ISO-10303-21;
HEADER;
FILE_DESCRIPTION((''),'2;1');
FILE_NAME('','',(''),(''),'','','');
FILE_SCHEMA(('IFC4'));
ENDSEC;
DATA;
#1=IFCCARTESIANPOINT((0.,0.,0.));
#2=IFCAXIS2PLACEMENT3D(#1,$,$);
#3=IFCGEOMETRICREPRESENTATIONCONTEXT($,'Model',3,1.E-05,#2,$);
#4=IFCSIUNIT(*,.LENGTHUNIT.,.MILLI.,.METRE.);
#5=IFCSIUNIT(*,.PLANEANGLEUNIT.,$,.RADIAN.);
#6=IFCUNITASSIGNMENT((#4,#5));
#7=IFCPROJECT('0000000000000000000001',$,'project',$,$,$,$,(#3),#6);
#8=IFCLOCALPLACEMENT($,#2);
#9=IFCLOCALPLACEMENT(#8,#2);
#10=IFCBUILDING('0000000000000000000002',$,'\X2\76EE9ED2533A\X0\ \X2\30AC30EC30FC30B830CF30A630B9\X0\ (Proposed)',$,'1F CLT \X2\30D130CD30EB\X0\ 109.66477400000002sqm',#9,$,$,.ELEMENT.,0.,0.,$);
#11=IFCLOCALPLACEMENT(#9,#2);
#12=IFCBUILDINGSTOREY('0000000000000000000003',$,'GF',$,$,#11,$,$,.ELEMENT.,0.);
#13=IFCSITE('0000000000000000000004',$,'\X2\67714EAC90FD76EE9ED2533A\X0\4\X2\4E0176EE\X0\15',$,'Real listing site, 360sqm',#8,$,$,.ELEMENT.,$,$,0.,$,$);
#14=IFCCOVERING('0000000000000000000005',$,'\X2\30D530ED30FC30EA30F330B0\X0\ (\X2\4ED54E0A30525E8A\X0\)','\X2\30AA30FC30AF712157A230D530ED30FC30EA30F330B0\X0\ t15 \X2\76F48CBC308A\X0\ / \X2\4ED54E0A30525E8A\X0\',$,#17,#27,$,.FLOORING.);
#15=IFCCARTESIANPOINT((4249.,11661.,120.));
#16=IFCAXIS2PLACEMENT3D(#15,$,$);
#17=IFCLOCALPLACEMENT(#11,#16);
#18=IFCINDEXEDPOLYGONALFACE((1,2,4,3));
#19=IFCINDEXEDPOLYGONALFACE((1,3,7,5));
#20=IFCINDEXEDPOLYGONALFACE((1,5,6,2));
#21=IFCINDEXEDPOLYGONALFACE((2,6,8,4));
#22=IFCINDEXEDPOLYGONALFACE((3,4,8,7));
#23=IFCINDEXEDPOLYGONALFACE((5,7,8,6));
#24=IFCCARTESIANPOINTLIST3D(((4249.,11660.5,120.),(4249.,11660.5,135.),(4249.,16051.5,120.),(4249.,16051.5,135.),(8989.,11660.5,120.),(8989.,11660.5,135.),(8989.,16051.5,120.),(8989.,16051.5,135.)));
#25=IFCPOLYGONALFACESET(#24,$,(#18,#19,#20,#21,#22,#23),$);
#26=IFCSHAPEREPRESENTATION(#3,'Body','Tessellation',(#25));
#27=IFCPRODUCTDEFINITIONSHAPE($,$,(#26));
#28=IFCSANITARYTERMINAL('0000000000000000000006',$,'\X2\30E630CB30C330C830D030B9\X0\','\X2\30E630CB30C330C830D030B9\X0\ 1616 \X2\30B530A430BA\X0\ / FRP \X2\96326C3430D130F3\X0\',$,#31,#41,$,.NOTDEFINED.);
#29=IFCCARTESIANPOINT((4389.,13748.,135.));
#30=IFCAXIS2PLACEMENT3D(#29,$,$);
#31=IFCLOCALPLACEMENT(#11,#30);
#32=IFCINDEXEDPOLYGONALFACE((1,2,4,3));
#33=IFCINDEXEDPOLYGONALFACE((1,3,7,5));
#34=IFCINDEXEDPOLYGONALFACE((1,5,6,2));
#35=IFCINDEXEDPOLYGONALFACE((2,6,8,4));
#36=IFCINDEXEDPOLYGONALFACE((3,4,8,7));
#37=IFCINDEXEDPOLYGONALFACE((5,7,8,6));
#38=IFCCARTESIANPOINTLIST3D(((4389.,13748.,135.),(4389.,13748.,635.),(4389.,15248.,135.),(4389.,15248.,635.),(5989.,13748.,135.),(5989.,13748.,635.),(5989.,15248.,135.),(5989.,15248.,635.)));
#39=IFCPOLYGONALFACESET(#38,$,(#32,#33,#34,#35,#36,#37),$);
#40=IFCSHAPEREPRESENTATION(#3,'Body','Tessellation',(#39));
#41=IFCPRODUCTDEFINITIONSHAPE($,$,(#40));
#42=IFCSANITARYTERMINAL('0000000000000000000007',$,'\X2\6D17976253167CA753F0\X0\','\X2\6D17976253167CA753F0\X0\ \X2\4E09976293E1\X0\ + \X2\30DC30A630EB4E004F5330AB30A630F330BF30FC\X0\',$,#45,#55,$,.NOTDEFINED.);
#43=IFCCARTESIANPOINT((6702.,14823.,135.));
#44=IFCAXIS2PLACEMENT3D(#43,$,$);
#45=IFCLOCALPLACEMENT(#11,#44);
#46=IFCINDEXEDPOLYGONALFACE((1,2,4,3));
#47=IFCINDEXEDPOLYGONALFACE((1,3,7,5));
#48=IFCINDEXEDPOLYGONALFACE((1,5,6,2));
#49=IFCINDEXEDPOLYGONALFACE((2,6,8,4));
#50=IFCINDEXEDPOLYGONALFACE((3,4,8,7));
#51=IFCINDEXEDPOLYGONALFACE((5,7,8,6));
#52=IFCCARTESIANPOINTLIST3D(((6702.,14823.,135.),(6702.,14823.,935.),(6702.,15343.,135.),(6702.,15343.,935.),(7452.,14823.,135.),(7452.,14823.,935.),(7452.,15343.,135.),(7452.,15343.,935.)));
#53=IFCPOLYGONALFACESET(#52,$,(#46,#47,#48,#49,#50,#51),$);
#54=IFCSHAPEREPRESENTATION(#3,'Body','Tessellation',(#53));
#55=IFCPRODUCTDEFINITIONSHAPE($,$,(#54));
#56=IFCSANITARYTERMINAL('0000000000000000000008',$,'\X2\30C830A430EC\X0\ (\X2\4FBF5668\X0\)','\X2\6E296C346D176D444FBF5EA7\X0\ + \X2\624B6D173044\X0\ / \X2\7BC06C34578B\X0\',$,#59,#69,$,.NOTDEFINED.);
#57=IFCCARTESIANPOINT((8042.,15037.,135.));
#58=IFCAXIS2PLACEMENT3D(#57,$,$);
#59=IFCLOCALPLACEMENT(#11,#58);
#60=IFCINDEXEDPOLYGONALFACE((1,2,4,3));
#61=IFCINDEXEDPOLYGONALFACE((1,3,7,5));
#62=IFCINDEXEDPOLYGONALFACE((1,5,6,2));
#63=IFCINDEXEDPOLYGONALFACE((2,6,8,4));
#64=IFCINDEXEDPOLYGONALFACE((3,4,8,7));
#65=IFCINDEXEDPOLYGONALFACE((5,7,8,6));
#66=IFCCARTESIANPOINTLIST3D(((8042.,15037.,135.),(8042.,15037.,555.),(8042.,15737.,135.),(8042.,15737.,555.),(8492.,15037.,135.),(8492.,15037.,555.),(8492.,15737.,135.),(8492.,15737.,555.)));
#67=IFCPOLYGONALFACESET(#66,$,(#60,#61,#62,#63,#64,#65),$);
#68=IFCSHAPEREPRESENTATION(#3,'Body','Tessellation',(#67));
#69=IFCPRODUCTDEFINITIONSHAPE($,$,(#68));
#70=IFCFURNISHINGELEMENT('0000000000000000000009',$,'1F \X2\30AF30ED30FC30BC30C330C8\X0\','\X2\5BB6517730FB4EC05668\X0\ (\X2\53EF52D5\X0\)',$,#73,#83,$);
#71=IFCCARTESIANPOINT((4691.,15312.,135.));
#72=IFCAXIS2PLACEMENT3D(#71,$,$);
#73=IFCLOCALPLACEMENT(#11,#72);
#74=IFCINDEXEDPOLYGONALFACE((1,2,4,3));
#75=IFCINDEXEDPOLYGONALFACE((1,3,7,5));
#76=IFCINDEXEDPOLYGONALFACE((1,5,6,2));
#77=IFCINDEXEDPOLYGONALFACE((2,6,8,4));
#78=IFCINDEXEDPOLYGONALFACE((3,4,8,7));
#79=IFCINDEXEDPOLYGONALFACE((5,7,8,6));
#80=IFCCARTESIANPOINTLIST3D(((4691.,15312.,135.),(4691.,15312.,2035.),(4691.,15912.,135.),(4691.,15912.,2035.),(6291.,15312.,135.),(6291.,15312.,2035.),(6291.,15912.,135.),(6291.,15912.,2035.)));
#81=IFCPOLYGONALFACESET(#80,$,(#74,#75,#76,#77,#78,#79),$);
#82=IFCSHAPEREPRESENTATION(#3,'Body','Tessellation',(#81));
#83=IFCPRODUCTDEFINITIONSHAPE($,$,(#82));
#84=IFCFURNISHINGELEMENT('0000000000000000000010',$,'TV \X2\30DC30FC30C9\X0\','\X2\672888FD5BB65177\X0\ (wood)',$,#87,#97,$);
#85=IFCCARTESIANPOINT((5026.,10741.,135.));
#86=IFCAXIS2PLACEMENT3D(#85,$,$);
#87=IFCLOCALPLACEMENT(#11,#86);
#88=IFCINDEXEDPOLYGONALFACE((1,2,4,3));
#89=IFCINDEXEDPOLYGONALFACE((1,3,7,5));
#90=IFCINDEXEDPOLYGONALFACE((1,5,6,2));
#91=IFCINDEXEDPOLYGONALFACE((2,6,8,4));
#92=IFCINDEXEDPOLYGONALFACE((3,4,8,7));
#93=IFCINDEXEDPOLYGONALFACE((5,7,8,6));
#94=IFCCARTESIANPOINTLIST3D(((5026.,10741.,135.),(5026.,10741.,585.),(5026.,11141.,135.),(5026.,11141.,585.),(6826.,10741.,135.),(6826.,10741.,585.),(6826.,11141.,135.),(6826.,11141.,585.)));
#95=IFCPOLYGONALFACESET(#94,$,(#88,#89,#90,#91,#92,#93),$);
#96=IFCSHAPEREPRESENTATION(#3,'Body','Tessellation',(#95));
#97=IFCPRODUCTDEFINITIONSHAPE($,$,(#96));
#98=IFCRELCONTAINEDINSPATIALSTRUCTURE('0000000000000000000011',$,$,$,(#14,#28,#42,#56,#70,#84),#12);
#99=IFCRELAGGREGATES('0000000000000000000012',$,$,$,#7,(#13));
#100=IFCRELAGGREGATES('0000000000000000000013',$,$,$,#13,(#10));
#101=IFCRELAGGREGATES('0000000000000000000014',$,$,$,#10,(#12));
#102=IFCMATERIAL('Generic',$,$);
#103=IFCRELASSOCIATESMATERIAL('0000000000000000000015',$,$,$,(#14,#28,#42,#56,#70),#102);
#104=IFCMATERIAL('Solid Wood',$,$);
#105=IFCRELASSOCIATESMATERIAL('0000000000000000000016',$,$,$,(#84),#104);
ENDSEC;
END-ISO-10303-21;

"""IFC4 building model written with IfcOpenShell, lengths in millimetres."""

from ifc_helpers import new_model, si_unit, frame, frame_2d, origin, place, context, project, spatial, rectangle, extrude, material, element, save


model = new_model("IFC4")

# Units and contexts
model_context = context("Model", 3, precision=1e-05, world=origin())
ifc_project = project(units=[si_unit("LENGTHUNIT", "METRE", prefix="MILLI"), si_unit("PLANEANGLEUNIT", "RADIAN")], contexts=[model_context])

# Site, building, storey
site_placement = place(None, origin())
site = spatial("IfcSite", under=ifc_project, at=site_placement, Name="東京都目黒区4丁目15", ObjectType="Real listing site, 360sqm", CompositionType="ELEMENT", RefElevation=0.0)
building_placement = place(site_placement, origin())
building = spatial("IfcBuilding", under=site, at=building_placement, Name="目黒区 ガレージハウス (Proposed)", ObjectType="1F CLT パネル 109.66477400000002sqm", CompositionType="ELEMENT", ElevationOfRefHeight=0.0, ElevationOfTerrain=0.0)
storey_placement = place(building_placement, origin())
storey = spatial("IfcBuildingStorey", under=building, at=storey_placement, Name="GF", CompositionType="ELEMENT", Elevation=0.0)

# Shared definitions
ifc_material_1 = material(Name="Solid Wood")

# Covering
ifc_material_2 = material(Name="Generic")
covering_placement = place(storey_placement, frame((4249.0, 11661.0, 120.0)))
element("IfcCovering", 1, at=covering_placement, inside=storey, material=ifc_material_2, Name="フローリング (仕上げ床)", Description="オーク無垢フローリング t15 直貼り / 仕上げ床", PredefinedType="FLOORING", context=model_context, shape_type="SweptSolid", body=[
    extrude(rectangle(XDim=4740.0, YDim=4391.0, at=frame_2d((2370.0, 2195.0))), frame((4249.0, 11661.0, 120.0)), (0.0, 0.0, 1.0), 15.0),
])

# Sanitary terminals
sanitary_terminal_1_placement = place(storey_placement, frame((4389.0, 13748.0, 135.0)))
element("IfcSanitaryTerminal", 2, at=sanitary_terminal_1_placement, inside=storey, material=ifc_material_2, Name="ユニットバス", Description="ユニットバス 1616 サイズ / FRP 防水パン", PredefinedType="NOTDEFINED", context=model_context, shape_type="SweptSolid", body=[
    extrude(rectangle(XDim=1600.0, YDim=1500.0, at=frame_2d((800.0, 750.0))), frame((4389.0, 13748.0, 135.0)), (0.0, 0.0, 1.0), 500.0),
])
sanitary_terminal_2_placement = place(storey_placement, frame((6702.0, 14823.0, 135.0)))
element("IfcSanitaryTerminal", 3, at=sanitary_terminal_2_placement, inside=storey, material=ifc_material_2, Name="洗面化粧台", Description="洗面化粧台 三面鏡 + ボウル一体カウンター", PredefinedType="NOTDEFINED", context=model_context, shape_type="SweptSolid", body=[
    extrude(rectangle(XDim=750.0, YDim=520.0, at=frame_2d((375.0, 260.0))), frame((6702.0, 14823.0, 135.0)), (0.0, 0.0, 1.0), 800.0),
])
sanitary_terminal_3_placement = place(storey_placement, frame((8042.0, 15037.0, 135.0)))
element("IfcSanitaryTerminal", 4, at=sanitary_terminal_3_placement, inside=storey, material=ifc_material_2, Name="トイレ (便器)", Description="温水洗浄便座 + 手洗い / 節水型", PredefinedType="NOTDEFINED", context=model_context, shape_type="SweptSolid", body=[
    extrude(rectangle(XDim=450.0, YDim=700.0, at=frame_2d((225.0, 350.0))), frame((8042.0, 15037.0, 135.0)), (0.0, 0.0, 1.0), 420.0),
])

# Furnishing elements
furnishing_1_placement = place(storey_placement, frame((4691.0, 15312.0, 135.0)))
element("IfcFurnishingElement", 5, at=furnishing_1_placement, inside=storey, material=ifc_material_2, Name="1F クローゼット", Description="家具・什器 (可動)", context=model_context, shape_type="SweptSolid", body=[
    extrude(rectangle(XDim=1600.0, YDim=600.0, at=frame_2d((800.0, 300.0))), frame((4691.0, 15312.0, 135.0)), (0.0, 0.0, 1.0), 1900.0),
])
furnishing_2_placement = place(storey_placement, frame((5026.0, 10741.0, 135.0)))
element("IfcFurnishingElement", 6, at=furnishing_2_placement, inside=storey, material=ifc_material_1, Name="TV ボード", Description="木製家具 (wood)", context=model_context, shape_type="SweptSolid", body=[
    extrude(rectangle(XDim=1800.0, YDim=400.0, at=frame_2d((900.0, 200.0))), frame((5026.0, 10741.0, 135.0)), (0.0, 0.0, 1.0), 450.0),
])

save(model, "model.ifc")
